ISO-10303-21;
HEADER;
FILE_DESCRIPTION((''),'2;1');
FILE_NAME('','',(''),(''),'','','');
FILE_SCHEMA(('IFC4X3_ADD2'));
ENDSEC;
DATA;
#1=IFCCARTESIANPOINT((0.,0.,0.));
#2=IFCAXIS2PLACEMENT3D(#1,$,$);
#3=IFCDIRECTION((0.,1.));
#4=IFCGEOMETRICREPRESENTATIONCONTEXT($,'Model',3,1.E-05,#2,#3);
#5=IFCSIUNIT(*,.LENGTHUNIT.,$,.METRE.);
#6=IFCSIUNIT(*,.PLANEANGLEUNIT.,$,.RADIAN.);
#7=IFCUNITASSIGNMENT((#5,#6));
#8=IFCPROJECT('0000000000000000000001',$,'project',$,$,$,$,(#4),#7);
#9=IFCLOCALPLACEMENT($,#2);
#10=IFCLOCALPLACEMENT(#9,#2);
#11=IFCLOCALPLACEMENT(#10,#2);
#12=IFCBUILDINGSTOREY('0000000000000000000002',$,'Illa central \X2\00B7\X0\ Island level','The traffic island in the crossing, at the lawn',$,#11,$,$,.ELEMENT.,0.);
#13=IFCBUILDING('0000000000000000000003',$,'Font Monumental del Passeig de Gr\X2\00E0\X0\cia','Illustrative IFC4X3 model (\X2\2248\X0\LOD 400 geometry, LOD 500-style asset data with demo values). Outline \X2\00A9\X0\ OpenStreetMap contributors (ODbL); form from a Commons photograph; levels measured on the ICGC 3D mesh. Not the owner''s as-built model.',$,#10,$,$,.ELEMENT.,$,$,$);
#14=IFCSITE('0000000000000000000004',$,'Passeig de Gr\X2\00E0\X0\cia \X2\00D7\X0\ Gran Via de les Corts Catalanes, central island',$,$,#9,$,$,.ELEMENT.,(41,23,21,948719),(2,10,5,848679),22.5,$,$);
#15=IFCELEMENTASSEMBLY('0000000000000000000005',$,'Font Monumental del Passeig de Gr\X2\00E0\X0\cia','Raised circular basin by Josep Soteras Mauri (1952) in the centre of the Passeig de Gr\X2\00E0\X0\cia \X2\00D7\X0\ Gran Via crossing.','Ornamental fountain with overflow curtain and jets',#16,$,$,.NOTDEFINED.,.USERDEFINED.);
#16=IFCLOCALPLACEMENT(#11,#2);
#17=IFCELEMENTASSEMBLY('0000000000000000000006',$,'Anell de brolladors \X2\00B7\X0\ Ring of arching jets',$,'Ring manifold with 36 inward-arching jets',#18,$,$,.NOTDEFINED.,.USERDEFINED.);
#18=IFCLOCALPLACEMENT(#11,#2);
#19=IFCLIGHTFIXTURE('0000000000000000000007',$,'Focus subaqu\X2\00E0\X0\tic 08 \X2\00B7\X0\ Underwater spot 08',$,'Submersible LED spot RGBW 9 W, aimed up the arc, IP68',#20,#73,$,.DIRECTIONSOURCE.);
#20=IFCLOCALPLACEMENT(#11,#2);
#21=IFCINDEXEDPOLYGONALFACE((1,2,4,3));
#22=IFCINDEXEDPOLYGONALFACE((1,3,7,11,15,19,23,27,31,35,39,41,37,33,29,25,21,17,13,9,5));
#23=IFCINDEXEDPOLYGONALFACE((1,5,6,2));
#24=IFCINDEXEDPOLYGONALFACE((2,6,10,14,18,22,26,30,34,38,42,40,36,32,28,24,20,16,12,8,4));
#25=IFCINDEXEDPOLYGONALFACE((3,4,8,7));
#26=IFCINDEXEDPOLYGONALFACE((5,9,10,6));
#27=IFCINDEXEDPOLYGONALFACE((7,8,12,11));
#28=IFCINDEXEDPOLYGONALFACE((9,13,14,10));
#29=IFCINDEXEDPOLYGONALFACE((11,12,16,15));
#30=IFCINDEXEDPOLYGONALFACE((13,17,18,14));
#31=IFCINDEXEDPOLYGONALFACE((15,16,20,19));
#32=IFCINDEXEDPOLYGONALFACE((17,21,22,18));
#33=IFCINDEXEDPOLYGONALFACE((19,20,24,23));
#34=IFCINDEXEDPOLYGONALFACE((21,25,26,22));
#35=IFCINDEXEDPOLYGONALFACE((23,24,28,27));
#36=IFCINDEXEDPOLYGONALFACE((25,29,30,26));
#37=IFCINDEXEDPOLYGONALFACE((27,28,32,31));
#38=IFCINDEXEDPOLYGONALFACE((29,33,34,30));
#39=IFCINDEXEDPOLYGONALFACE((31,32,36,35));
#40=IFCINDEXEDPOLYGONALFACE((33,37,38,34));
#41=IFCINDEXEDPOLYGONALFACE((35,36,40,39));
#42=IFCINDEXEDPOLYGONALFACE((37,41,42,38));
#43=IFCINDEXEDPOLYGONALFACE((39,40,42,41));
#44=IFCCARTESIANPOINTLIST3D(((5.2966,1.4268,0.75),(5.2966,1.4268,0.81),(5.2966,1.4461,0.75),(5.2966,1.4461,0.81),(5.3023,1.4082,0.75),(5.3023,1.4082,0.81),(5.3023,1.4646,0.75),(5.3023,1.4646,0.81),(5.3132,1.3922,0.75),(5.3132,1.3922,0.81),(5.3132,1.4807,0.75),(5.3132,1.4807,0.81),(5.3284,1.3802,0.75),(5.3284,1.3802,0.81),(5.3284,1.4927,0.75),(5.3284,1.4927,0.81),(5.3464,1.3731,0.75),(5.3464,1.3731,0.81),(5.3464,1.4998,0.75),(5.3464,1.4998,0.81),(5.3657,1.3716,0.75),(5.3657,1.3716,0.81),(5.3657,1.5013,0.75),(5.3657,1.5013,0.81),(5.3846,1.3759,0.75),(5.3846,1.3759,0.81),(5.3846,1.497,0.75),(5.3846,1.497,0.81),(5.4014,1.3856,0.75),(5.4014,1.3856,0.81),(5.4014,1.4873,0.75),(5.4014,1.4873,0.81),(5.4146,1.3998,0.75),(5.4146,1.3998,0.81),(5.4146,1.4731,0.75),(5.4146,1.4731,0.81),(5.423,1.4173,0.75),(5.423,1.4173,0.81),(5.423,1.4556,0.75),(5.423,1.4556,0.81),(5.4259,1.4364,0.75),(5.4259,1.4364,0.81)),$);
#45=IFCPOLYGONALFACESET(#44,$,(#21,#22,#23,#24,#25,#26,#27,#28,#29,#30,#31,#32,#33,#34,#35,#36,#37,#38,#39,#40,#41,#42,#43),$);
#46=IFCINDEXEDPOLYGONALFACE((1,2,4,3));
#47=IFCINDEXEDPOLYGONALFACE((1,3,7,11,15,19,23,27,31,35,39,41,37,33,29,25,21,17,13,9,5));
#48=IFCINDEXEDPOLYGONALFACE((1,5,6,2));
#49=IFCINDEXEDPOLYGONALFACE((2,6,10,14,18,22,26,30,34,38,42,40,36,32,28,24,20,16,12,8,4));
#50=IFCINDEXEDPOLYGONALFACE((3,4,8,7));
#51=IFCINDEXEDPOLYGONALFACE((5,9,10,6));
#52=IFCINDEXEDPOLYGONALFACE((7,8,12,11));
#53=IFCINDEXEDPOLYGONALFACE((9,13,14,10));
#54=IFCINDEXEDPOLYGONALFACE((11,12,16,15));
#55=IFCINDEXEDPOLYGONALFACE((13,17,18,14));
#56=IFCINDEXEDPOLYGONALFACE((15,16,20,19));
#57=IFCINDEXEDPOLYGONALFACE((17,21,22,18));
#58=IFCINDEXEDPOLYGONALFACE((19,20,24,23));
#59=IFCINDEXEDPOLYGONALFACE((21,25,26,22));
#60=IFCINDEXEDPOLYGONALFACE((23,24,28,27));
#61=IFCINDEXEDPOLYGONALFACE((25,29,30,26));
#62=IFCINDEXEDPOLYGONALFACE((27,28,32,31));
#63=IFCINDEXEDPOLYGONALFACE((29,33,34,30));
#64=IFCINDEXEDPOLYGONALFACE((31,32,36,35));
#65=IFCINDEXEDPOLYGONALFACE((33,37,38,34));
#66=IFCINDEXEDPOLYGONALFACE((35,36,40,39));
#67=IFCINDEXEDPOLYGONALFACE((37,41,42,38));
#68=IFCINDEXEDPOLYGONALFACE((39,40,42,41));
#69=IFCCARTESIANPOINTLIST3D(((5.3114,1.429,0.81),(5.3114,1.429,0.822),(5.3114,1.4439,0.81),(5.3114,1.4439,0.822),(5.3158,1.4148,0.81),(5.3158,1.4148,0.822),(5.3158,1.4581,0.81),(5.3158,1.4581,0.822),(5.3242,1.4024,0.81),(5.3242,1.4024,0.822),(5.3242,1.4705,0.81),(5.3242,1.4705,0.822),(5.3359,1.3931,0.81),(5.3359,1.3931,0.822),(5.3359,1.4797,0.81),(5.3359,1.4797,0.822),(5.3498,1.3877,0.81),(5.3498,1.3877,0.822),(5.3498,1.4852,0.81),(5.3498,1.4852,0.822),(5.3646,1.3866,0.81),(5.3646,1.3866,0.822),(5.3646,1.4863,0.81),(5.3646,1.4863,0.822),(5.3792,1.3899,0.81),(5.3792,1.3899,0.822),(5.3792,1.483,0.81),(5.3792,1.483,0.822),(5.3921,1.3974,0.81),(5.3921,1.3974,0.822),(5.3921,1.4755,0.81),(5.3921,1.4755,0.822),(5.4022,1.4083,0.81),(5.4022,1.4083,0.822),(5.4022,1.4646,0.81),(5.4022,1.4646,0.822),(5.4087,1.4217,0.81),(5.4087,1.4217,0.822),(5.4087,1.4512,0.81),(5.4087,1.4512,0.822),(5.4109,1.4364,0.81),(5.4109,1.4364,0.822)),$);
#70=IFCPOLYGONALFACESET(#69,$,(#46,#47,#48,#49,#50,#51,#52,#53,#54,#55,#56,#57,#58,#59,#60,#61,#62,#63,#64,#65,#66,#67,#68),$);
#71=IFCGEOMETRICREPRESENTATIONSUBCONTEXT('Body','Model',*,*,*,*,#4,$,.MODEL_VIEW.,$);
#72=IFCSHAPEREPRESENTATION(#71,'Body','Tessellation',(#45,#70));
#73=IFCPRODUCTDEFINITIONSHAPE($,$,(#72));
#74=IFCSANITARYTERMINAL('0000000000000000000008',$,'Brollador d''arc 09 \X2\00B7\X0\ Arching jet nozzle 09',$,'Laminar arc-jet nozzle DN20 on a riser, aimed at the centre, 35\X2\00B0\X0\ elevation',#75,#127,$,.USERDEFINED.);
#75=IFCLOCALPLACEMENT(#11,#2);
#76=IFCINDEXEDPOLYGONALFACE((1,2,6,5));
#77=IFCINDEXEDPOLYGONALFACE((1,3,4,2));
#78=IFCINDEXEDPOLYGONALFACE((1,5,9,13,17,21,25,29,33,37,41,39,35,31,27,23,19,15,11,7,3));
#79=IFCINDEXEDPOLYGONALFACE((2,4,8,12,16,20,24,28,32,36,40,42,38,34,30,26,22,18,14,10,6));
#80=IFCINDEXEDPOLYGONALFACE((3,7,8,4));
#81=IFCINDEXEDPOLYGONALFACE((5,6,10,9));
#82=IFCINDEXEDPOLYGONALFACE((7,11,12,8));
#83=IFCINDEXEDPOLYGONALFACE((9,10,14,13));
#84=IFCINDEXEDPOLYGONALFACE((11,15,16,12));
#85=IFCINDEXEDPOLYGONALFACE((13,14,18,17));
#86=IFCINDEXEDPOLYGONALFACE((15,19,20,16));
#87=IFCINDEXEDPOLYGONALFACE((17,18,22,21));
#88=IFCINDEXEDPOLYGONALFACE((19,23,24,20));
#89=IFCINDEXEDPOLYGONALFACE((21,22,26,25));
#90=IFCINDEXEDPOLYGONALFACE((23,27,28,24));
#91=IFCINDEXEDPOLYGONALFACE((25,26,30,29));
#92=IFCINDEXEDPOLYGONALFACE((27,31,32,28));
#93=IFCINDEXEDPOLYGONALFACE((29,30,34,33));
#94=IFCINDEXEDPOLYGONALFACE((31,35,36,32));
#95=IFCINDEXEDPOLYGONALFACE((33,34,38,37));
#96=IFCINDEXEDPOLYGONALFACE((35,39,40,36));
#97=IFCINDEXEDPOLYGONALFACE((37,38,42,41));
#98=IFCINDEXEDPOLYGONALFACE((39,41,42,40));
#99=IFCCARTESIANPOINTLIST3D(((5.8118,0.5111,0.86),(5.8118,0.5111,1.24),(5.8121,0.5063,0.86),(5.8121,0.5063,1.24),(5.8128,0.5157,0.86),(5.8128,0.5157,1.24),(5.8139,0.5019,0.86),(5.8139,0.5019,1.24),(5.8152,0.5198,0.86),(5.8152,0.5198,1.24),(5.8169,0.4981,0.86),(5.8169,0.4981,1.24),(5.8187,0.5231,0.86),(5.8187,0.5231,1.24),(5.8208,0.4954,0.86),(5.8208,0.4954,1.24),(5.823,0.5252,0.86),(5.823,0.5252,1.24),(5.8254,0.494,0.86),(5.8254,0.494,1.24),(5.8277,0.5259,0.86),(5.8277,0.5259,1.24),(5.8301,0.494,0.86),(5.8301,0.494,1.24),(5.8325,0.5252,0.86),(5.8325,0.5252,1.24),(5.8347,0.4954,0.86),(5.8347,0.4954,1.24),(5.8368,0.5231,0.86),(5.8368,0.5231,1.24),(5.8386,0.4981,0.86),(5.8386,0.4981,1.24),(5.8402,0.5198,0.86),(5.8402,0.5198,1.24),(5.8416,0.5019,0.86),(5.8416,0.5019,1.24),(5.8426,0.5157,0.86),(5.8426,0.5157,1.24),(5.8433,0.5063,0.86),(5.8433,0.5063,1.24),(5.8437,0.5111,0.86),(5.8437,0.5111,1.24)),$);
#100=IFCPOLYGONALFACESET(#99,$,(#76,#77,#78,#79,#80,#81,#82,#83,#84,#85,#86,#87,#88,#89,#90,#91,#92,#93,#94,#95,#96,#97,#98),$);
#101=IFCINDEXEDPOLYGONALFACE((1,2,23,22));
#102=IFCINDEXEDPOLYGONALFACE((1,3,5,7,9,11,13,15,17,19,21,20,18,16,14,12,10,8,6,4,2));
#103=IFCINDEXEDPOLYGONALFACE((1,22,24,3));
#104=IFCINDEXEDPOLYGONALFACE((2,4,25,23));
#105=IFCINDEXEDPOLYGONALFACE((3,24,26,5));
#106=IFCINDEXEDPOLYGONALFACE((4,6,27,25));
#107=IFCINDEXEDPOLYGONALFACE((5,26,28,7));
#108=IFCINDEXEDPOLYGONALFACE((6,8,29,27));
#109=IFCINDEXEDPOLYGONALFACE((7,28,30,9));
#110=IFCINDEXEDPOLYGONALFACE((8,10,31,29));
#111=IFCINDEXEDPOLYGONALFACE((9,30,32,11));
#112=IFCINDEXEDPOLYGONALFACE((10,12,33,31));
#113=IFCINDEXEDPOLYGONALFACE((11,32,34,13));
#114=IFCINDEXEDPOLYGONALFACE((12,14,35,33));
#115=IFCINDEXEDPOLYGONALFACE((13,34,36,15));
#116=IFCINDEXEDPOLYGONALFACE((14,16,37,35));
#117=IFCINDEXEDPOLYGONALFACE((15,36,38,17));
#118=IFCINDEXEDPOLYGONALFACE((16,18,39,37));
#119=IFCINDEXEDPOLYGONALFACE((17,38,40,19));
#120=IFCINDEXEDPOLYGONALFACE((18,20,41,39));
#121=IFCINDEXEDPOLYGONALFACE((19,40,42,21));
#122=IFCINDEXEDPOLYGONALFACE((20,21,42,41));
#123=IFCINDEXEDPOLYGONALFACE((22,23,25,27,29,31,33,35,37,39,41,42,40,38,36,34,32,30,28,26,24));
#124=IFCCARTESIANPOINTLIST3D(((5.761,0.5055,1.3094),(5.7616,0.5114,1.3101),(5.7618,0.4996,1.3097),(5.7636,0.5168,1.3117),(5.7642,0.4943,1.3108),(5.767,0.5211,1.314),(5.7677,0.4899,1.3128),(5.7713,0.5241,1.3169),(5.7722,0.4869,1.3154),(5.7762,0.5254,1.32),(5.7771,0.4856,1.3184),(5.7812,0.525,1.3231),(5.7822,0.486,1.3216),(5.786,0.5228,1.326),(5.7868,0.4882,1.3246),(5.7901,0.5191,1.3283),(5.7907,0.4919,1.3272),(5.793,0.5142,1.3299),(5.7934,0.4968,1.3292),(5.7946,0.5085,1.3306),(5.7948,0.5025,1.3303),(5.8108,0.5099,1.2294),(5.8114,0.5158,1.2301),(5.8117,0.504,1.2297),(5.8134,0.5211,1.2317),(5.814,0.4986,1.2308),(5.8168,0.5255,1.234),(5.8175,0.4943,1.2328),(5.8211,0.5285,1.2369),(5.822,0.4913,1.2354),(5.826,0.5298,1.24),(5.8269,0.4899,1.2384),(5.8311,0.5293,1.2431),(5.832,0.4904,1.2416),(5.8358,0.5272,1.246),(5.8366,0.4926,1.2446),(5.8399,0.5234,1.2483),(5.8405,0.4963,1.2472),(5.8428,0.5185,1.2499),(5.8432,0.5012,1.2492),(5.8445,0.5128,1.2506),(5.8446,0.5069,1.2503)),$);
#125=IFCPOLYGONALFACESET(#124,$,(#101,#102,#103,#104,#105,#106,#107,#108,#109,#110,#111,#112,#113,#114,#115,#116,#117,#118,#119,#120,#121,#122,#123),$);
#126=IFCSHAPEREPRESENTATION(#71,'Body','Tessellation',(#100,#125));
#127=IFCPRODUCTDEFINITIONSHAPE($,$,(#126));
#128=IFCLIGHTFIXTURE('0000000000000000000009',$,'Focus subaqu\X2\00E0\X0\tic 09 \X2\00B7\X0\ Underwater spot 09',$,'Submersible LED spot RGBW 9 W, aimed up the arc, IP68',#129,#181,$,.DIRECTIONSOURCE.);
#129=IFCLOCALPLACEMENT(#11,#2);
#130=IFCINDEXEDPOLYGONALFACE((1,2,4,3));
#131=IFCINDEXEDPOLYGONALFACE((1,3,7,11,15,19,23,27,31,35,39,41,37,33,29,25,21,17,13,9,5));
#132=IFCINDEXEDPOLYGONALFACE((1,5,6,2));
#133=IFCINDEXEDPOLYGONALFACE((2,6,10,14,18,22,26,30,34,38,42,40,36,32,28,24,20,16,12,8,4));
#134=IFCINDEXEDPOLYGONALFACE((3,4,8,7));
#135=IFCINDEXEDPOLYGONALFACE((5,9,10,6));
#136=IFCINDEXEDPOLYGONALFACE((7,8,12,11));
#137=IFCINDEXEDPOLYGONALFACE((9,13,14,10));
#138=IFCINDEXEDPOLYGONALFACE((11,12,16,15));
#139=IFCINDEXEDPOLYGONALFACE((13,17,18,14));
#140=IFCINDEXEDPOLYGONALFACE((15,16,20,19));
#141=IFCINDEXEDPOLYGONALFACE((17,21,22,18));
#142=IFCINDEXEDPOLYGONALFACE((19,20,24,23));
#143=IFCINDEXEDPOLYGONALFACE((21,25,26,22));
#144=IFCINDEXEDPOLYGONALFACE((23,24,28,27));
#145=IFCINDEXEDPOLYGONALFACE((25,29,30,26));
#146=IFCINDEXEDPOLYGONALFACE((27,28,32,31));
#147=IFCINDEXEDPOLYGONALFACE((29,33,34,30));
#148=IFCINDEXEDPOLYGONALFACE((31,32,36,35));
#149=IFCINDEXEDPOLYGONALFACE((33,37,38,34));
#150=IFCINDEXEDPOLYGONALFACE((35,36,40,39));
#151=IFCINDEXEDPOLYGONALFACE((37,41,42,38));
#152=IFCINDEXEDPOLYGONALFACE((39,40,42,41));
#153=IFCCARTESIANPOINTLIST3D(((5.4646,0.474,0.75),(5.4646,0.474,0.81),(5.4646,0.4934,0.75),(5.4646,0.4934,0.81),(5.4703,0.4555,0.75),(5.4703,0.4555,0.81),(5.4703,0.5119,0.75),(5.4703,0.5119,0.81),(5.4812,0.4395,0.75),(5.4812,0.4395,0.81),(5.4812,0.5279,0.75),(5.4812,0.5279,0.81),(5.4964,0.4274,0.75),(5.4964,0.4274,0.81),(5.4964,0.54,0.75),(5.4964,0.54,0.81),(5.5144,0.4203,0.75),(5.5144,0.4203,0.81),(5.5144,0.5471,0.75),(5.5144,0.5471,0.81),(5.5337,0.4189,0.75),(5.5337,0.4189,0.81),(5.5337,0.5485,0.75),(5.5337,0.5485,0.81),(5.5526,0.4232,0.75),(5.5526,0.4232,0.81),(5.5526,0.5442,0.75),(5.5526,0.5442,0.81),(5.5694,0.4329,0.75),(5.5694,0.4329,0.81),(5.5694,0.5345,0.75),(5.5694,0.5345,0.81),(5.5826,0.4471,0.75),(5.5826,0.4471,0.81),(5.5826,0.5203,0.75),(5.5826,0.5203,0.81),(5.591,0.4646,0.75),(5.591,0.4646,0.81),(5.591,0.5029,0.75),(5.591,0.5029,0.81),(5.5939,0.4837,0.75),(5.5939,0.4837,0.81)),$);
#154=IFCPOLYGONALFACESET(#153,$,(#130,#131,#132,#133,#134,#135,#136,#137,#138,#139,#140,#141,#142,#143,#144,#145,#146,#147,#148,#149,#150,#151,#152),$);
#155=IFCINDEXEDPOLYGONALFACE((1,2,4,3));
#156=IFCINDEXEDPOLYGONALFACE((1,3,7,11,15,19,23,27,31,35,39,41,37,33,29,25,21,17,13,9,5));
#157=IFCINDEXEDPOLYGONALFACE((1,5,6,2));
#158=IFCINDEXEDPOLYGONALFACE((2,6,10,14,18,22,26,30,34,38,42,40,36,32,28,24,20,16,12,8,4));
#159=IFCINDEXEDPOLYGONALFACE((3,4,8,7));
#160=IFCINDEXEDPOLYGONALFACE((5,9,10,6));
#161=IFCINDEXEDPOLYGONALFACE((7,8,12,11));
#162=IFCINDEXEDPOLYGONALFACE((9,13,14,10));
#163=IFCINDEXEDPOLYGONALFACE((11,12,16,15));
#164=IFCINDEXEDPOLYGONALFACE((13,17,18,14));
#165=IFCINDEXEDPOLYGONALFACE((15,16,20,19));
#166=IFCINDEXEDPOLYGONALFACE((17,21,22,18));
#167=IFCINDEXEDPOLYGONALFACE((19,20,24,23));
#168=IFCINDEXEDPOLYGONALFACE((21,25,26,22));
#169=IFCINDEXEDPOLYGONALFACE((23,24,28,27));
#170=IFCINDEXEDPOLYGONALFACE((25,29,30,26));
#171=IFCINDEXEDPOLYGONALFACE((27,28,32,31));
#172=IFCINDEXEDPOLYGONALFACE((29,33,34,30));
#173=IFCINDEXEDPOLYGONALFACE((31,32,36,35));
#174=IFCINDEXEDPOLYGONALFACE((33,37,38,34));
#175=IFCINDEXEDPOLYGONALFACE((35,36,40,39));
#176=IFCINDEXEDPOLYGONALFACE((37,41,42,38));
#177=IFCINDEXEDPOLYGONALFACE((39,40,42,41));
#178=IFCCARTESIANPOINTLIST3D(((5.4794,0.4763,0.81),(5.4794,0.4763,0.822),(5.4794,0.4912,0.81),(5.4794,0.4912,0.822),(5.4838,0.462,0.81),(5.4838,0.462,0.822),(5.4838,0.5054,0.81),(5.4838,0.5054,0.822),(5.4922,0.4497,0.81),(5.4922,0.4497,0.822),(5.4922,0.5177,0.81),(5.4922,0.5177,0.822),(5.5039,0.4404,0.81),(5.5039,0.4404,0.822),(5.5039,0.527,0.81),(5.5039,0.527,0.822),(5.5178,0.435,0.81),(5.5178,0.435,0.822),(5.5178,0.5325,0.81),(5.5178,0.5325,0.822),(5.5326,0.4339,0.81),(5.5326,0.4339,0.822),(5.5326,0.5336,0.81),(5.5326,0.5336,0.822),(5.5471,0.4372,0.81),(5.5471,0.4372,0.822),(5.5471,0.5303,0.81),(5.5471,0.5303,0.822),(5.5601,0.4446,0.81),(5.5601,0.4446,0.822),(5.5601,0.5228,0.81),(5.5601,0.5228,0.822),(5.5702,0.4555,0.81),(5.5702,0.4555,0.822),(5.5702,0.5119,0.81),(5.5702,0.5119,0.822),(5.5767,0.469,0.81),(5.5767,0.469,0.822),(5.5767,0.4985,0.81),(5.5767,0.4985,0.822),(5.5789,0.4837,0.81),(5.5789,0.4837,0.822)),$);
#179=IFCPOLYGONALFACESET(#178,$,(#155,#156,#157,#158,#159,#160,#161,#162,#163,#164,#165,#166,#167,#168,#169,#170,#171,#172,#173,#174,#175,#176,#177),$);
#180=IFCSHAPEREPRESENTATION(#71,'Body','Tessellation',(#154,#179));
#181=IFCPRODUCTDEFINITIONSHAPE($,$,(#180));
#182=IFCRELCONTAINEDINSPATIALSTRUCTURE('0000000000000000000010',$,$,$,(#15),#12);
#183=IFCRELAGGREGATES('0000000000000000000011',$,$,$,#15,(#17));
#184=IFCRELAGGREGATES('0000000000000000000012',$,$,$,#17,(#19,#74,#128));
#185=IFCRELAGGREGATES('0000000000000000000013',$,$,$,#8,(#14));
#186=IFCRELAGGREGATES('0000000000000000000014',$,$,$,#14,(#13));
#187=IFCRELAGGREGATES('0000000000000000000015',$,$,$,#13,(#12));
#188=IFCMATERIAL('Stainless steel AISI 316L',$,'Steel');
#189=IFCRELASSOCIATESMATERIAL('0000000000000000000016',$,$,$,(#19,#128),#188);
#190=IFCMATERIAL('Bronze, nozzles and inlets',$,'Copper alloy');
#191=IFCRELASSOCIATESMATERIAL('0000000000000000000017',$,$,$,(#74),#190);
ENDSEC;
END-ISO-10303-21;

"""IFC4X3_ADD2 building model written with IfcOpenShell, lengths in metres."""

from ifc_helpers import new_model, si_unit, direction, frame, origin, origin_2d_with_axis, place, context, subcontext, project, spatial, circle, extrude, material, element, aggregate, save


model = new_model("IFC4X3_ADD2")

# Units and contexts
model_context = context("Model", 3, precision=1e-05, world=origin(), true_north=direction((0.0, 1.0)))
body_context = subcontext(model_context, "Body", "Model", "MODEL_VIEW")
ifc_project = project(units=[si_unit("LENGTHUNIT", "METRE"), si_unit("PLANEANGLEUNIT", "RADIAN")], contexts=[model_context])

# Site, building, storey
site_placement = place(None, origin())
site = spatial("IfcSite", under=ifc_project, at=site_placement, Name="Passeig de Gràcia × Gran Via de les Corts Catalanes, central island", CompositionType="ELEMENT", RefLatitude=(41, 23, 21, 948719), RefLongitude=(2, 10, 5, 848679), RefElevation=22.5)
building_placement = place(site_placement, origin())
building = spatial("IfcBuilding", under=site, at=building_placement, Name="Font Monumental del Passeig de Gràcia", Description="Illustrative IFC4X3 model (≈LOD 400 geometry, LOD 500-style asset data with demo values). Outline © OpenStreetMap contributors (ODbL); form from a Commons photograph; levels measured on the ICGC 3D mesh. Not the owner's as-built model.", CompositionType="ELEMENT")
storey_placement = place(building_placement, origin())
storey = spatial("IfcBuildingStorey", under=building, at=storey_placement, Name="Illa central · Island level", Description="The traffic island in the crossing, at the lawn", CompositionType="ELEMENT", Elevation=0.0)

# Element assemblies, light fixtures, sanitary terminal
assembly_1_placement = place(building_placement, origin())
assembly_1 = element("IfcElementAssembly", 1, at=assembly_1_placement, inside=storey, Name="Font Monumental del Passeig de Gràcia", Description="Raised circular basin by Josep Soteras Mauri (1952) in the centre of the Passeig de Gràcia × Gran Via crossing.", ObjectType="Ornamental fountain with overflow curtain and jets", AssemblyPlace="NOTDEFINED", PredefinedType="USERDEFINED")
assembly_2_placement = place(building_placement, origin())
assembly_2 = element("IfcElementAssembly", 2, at=assembly_2_placement, Name="Anell de brolladors · Ring of arching jets", ObjectType="Ring manifold with 36 inward-arching jets", AssemblyPlace="NOTDEFINED", PredefinedType="USERDEFINED")
aggregate(assembly_1, [assembly_2])
ifc_material_1 = material(Name="Bronze, nozzles and inlets", Category="Copper alloy")
ifc_material_2 = material(Name="Stainless steel AISI 316L", Category="Steel")
light_fixture_1_placement = place(building_placement, origin())
light_fixture_1 = element("IfcLightFixture", 3, at=light_fixture_1_placement, material=ifc_material_2, Name="Focus subaquàtic 08 · Underwater spot 08", ObjectType="Submersible LED spot RGBW 9 W, aimed up the arc, IP68", PredefinedType="DIRECTIONSOURCE", context=body_context, shape_type="SweptSolid", body=[
    extrude(circle(Radius=0.065, at=origin_2d_with_axis()), frame((5.3609, 1.4364, 0.75)), (0.0, 0.0, 1.0), 0.06),
    extrude(circle(Radius=0.05, at=origin_2d_with_axis()), frame((5.3609, 1.4364, 0.81)), (0.0, 0.0, 1.0), 0.012),
])
sanitary_terminal_1_placement = place(building_placement, origin())
sanitary_terminal_1 = element("IfcSanitaryTerminal", 4, at=sanitary_terminal_1_placement, material=ifc_material_1, Name="Brollador d'arc 09 · Arching jet nozzle 09", ObjectType="Laminar arc-jet nozzle DN20 on a riser, aimed at the centre, 35° elevation", PredefinedType="USERDEFINED", context=body_context, shape_type="SweptSolid", body=[
    extrude(circle(Radius=0.016, at=origin_2d_with_axis()), frame((5.8277, 0.5099, 0.86), z_axis=(0.0, 0.0, 1.0), x_axis=(0.0, 1.0, 0.0)), (0.0, 0.0, 1.0), 0.38),
    extrude(circle(Radius=0.02, at=origin_2d_with_axis()), frame((5.8277, 0.5099, 1.24), z_axis=(-0.527982, -0.046192, 0.847998), x_axis=(-0.087156, 0.996195, 0.0)), (0.0, 0.0, 1.0), 0.0943),
])
light_fixture_2_placement = place(building_placement, origin())
light_fixture_2 = element("IfcLightFixture", 5, at=light_fixture_2_placement, material=ifc_material_2, Name="Focus subaquàtic 09 · Underwater spot 09", ObjectType="Submersible LED spot RGBW 9 W, aimed up the arc, IP68", PredefinedType="DIRECTIONSOURCE", context=body_context, shape_type="SweptSolid", body=[
    extrude(circle(Radius=0.065, at=origin_2d_with_axis()), frame((5.5289, 0.4837, 0.75)), (0.0, 0.0, 1.0), 0.06),
    extrude(circle(Radius=0.05, at=origin_2d_with_axis()), frame((5.5289, 0.4837, 0.81)), (0.0, 0.0, 1.0), 0.012),
])
aggregate(assembly_2, [light_fixture_1, sanitary_terminal_1, light_fixture_2])

save(model, "model.ifc")
